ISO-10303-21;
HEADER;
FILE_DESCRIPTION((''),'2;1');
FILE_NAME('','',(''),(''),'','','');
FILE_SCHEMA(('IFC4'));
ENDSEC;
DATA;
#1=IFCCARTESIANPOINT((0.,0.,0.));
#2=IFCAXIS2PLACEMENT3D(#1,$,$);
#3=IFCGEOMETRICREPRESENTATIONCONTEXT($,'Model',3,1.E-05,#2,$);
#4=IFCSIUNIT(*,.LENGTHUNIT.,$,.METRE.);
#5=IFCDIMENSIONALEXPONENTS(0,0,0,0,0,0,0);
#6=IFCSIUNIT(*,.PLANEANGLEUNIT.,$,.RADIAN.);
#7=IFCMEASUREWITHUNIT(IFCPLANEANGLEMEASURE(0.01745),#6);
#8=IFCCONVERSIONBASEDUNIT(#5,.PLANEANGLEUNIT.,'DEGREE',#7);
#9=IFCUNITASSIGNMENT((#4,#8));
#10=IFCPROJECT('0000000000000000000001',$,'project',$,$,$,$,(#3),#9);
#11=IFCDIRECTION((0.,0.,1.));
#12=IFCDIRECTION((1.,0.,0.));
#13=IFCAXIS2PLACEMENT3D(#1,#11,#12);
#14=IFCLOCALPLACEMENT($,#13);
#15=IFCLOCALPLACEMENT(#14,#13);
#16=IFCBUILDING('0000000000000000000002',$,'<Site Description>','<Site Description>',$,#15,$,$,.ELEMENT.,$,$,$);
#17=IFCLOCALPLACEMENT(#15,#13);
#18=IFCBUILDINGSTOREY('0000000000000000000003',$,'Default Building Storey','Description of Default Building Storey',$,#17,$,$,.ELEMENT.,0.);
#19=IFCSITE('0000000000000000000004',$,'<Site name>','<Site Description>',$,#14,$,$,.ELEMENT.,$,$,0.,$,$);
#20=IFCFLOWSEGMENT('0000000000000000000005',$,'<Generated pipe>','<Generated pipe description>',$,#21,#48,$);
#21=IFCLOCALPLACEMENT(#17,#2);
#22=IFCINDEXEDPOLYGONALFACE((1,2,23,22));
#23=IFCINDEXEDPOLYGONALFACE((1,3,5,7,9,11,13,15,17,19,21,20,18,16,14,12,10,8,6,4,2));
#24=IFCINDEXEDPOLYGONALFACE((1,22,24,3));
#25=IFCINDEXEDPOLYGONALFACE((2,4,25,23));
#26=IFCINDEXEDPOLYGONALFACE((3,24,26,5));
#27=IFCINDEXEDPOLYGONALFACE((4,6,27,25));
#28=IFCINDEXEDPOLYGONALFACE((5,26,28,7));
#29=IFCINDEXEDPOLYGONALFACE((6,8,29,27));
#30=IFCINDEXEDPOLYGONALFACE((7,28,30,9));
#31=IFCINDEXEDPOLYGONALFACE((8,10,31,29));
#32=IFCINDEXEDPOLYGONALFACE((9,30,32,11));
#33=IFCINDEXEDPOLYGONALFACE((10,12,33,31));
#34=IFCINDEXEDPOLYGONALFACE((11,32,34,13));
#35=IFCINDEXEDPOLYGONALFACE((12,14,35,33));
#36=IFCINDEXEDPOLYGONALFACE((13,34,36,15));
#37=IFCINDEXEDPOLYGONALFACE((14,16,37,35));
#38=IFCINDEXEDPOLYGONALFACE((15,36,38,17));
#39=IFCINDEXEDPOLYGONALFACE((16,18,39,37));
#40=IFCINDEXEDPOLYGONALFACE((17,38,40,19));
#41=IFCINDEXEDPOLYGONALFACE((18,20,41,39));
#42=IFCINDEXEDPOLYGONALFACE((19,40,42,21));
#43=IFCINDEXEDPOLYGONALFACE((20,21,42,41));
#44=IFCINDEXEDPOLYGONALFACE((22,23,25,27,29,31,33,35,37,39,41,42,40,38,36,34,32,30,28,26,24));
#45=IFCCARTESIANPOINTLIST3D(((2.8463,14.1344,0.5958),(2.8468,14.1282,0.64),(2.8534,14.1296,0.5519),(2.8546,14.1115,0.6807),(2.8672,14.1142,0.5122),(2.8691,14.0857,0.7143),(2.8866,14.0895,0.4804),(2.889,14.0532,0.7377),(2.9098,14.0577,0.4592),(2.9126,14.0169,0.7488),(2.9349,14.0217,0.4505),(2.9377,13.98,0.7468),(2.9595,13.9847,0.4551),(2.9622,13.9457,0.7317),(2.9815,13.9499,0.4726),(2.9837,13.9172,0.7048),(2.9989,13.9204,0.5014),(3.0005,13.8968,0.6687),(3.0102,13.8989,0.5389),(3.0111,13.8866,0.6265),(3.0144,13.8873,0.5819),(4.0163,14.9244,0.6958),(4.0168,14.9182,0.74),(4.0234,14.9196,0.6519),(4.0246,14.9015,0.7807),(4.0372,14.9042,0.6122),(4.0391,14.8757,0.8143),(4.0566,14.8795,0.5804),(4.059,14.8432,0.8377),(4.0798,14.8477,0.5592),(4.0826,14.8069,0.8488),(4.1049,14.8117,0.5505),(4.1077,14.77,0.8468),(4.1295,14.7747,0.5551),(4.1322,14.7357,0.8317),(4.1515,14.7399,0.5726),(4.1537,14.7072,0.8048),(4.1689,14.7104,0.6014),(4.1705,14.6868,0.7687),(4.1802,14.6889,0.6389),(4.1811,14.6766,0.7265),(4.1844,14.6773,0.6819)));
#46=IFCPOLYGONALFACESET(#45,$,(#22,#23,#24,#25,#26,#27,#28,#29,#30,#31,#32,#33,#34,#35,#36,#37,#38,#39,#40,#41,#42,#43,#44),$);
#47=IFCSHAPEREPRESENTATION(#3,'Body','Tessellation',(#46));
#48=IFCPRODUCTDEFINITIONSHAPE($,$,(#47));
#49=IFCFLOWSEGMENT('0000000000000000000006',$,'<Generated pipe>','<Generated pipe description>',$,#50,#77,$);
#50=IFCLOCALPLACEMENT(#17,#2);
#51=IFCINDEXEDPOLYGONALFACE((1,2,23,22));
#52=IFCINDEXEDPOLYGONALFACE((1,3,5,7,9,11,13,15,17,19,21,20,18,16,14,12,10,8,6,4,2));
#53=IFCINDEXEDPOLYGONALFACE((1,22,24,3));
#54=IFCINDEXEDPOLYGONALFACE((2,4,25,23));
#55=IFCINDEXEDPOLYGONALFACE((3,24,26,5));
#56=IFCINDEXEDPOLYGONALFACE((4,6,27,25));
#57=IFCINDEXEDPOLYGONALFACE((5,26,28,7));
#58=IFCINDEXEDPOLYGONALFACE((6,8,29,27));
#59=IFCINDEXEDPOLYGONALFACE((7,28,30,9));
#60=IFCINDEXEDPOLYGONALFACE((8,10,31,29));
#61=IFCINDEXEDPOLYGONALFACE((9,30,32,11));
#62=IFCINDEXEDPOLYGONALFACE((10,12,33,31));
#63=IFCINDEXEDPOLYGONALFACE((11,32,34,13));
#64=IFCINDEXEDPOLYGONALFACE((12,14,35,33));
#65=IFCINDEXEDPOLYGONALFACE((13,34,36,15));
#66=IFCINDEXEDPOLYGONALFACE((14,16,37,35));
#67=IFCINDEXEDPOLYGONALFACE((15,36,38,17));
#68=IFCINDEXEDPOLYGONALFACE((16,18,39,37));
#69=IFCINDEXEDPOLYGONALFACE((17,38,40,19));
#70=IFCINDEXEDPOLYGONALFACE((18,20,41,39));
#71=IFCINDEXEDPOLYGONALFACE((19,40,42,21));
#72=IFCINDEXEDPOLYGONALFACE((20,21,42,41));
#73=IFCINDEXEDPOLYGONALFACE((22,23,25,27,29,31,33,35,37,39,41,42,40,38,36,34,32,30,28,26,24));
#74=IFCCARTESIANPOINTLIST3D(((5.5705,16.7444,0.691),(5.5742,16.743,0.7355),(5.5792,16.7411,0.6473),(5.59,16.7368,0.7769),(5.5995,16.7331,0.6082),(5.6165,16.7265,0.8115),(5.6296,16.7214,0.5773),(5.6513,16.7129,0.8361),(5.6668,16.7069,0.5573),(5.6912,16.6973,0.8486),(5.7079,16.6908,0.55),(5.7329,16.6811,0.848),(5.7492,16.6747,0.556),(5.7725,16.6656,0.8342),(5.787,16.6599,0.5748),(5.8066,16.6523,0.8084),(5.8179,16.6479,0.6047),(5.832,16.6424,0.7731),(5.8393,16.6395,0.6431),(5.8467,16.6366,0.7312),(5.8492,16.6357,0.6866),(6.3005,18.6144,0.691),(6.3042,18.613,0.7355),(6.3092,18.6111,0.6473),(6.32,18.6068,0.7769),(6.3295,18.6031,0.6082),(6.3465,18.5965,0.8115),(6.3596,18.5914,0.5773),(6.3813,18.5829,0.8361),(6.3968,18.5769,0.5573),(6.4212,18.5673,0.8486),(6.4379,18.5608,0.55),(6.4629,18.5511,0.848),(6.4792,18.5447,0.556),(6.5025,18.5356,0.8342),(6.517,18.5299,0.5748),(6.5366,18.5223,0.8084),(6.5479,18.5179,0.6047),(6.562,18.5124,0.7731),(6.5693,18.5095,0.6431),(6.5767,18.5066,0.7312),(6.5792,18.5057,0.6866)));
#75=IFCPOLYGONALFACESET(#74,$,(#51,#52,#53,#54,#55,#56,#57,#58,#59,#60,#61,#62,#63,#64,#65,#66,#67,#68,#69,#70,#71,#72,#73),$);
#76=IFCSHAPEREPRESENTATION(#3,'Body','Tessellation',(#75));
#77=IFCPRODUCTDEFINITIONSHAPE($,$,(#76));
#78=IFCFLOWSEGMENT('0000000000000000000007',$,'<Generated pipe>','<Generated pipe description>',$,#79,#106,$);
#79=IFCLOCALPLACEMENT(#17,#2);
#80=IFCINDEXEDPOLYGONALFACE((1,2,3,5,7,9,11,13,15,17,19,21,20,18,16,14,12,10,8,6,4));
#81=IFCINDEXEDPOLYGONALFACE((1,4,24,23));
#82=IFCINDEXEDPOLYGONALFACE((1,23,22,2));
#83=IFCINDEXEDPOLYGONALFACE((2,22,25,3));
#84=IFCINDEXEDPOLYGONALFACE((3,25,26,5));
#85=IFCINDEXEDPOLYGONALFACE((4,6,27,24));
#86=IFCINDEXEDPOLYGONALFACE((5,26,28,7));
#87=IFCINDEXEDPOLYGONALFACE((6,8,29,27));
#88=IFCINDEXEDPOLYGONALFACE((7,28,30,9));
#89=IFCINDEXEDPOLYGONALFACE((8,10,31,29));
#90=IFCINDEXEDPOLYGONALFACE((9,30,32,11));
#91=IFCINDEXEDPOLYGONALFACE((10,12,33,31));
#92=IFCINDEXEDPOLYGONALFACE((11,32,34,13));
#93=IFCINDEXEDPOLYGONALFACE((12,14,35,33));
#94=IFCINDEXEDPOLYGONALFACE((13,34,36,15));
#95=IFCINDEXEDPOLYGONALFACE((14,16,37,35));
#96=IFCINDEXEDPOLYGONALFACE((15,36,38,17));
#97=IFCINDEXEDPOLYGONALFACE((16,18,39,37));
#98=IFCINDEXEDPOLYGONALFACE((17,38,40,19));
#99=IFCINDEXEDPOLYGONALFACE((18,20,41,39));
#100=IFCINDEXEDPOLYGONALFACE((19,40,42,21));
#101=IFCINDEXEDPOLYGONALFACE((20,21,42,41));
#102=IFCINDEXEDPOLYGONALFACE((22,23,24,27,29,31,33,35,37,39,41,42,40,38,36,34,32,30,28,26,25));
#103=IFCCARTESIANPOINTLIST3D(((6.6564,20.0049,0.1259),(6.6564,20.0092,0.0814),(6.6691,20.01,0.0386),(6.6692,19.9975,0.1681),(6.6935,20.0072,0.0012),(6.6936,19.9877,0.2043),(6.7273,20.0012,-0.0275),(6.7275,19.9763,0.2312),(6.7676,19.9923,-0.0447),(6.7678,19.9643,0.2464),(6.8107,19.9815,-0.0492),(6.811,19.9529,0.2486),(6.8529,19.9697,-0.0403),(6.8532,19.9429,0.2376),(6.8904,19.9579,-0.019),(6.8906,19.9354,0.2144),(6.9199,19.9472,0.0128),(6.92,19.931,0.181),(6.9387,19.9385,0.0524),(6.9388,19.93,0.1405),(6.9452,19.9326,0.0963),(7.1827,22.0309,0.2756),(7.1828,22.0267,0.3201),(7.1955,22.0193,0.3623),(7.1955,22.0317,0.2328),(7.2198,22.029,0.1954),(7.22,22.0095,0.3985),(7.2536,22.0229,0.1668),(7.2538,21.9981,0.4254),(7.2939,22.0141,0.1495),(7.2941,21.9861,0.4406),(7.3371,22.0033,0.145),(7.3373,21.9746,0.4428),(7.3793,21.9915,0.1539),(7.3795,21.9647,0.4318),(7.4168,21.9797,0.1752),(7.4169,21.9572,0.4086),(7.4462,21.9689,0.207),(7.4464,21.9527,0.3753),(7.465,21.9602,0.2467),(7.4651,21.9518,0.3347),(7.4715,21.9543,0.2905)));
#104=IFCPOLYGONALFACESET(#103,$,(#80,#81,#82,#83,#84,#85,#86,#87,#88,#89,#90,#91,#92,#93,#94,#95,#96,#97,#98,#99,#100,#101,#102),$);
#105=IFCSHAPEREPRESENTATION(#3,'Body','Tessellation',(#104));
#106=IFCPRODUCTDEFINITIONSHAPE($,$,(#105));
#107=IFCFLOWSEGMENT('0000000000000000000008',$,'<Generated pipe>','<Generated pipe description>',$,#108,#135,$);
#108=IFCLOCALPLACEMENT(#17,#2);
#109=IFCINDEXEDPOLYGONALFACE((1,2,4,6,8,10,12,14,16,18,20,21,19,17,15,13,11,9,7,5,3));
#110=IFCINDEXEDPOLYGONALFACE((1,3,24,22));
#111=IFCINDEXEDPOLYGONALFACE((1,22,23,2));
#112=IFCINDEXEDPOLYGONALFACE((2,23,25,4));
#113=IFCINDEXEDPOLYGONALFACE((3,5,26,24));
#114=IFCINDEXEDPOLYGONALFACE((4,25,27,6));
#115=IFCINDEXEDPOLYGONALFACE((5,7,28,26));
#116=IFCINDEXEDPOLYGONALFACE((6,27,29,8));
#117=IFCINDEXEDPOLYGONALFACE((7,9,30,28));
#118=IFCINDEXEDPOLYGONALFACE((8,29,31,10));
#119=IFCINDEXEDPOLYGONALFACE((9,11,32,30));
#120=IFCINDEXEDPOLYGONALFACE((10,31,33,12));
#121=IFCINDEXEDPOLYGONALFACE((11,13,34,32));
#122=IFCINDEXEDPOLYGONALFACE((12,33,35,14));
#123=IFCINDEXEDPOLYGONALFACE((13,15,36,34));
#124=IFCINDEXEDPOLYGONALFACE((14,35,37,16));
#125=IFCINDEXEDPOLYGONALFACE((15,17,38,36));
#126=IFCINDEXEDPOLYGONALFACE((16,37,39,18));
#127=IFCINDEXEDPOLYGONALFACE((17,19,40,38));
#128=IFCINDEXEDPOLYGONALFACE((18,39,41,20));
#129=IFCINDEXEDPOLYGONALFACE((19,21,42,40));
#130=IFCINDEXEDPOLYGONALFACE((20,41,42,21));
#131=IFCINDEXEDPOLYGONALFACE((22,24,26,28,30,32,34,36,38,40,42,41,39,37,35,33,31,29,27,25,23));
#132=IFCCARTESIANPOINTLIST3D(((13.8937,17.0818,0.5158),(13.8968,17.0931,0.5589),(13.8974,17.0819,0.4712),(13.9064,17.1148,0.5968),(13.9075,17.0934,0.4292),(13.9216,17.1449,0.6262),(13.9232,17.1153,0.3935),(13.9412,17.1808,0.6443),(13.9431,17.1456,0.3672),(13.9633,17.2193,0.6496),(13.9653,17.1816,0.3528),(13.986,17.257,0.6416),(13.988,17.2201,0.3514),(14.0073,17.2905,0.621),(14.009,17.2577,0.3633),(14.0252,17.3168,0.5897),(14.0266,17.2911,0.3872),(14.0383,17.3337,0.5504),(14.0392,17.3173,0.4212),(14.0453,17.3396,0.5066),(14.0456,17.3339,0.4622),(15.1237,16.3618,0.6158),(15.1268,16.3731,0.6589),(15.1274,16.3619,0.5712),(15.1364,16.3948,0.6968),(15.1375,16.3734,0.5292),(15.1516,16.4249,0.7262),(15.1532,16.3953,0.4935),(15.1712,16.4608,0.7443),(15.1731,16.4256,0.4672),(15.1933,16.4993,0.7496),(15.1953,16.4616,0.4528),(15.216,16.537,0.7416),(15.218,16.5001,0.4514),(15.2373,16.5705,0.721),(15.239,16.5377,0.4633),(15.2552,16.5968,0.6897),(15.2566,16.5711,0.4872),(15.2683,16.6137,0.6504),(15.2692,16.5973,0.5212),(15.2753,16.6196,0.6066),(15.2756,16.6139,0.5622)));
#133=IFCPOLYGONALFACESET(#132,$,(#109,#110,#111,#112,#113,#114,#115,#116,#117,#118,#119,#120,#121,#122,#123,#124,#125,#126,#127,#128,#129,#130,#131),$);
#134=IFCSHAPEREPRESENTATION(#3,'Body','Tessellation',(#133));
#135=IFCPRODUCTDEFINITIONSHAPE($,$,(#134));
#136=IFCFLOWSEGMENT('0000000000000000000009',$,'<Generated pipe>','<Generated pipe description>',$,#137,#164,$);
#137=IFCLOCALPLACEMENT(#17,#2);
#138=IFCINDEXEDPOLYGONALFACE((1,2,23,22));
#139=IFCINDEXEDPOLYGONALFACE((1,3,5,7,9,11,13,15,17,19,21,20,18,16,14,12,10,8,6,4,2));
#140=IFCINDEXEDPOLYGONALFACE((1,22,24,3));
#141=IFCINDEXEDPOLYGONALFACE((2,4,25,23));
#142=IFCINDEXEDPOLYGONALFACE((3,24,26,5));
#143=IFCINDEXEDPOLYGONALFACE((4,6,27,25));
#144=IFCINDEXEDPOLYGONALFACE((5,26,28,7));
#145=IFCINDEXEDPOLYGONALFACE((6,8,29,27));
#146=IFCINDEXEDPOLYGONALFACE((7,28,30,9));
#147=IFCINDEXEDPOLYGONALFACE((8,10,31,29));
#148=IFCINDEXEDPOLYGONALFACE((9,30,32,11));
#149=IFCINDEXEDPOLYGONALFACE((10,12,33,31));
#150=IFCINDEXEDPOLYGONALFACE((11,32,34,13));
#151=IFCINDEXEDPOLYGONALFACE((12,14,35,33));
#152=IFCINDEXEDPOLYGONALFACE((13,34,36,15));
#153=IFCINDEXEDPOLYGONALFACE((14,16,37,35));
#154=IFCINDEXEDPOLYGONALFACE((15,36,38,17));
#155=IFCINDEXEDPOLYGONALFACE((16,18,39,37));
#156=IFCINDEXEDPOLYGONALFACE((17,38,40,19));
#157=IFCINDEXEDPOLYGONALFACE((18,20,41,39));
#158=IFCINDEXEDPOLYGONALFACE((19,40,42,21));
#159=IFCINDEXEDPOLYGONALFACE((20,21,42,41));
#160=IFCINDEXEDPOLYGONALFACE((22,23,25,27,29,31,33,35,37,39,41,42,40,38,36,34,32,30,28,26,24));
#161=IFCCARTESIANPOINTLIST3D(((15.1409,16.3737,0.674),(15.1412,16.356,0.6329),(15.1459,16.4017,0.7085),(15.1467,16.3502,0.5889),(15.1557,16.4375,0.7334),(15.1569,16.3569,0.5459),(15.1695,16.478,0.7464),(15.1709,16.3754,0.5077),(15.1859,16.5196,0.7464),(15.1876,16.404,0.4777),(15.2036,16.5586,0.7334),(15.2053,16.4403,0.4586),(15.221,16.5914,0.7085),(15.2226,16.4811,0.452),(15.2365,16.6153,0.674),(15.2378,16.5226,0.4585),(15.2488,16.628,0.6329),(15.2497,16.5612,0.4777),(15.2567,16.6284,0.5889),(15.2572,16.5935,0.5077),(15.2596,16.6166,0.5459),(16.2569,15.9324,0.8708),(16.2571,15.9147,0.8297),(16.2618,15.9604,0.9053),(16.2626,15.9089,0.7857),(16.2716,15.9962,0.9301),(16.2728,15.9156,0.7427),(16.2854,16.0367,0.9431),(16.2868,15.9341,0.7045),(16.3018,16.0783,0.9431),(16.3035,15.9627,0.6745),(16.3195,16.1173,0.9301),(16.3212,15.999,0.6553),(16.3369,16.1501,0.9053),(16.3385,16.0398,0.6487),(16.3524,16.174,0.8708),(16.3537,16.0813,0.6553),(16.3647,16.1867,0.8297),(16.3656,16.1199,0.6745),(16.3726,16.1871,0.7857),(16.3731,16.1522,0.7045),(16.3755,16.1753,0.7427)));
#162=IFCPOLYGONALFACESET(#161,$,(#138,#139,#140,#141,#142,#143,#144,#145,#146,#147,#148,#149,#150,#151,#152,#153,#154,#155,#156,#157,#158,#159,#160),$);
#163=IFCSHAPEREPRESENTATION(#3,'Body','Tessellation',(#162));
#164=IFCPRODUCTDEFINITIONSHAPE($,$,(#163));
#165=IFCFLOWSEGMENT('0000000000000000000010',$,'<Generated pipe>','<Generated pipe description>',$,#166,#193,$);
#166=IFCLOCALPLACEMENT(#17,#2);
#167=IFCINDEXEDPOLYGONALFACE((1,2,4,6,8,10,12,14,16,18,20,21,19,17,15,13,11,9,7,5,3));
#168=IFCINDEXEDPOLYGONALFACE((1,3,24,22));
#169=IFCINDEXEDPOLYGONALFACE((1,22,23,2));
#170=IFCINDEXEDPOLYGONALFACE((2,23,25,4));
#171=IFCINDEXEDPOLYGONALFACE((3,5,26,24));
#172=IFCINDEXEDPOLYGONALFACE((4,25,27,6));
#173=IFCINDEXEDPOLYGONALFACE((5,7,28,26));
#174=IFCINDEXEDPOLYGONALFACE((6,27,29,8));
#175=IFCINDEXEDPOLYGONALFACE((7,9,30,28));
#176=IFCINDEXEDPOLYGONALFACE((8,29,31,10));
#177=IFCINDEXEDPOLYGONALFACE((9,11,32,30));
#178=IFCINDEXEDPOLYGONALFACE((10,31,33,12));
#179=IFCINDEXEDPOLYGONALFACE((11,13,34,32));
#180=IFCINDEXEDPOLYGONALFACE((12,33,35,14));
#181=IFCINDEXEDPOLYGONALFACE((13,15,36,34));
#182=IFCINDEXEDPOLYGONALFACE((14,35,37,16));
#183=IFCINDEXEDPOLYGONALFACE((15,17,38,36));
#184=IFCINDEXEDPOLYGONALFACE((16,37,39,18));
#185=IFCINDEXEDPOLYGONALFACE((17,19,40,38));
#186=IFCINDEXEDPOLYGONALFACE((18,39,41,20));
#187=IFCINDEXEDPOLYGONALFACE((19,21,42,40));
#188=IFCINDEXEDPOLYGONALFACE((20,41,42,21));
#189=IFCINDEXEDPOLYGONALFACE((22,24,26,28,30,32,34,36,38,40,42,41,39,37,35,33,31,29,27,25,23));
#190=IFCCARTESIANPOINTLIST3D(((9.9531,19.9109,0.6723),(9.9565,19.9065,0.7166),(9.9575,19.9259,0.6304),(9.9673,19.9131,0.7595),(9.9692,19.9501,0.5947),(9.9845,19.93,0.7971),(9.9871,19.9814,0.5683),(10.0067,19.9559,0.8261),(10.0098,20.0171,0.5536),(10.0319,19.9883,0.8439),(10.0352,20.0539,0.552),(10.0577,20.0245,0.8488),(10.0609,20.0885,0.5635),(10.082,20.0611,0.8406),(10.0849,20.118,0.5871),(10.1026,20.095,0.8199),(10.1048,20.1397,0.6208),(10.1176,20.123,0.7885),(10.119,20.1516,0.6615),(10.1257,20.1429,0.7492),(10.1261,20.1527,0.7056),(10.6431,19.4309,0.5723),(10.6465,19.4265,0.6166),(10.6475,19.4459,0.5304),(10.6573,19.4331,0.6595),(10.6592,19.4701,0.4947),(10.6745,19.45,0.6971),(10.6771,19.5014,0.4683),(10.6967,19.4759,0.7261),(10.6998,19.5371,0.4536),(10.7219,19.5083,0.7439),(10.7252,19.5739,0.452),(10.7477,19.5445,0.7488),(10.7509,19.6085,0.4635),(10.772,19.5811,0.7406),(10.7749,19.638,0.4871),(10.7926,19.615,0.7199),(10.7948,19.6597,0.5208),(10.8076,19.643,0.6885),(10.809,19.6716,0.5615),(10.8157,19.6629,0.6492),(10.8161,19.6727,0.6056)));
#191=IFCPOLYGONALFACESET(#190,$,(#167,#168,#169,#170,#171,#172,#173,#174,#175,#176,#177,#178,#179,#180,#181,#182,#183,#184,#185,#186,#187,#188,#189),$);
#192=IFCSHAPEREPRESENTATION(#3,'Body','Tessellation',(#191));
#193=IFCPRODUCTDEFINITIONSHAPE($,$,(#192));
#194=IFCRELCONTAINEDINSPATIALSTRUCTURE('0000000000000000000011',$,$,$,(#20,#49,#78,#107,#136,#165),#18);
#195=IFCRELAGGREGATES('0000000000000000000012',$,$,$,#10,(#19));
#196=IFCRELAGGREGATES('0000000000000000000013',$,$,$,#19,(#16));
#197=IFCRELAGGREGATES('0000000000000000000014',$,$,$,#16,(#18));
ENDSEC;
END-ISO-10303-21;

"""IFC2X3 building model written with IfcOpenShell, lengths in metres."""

from ifc_helpers import new_model, entity, si_unit, converted_unit, frame, origin, origin_with_axes, origin_2d_with_axis, place, context, project, spatial, circle, extrude, element, save


model = new_model("IFC2X3")

# Units and contexts
model_context = context("Model", 3, precision=1e-05, world=origin())
ifc_project = project(units=[si_unit("LENGTHUNIT", "METRE"), converted_unit("PLANEANGLEUNIT", "DEGREE", entity("IfcPlaneAngleMeasure", 0.01745), si_unit("PLANEANGLEUNIT", "RADIAN"), dimensions=[0, 0, 0, 0, 0, 0, 0])], contexts=[model_context])

# Site, building, storey
site_placement = place(None, origin_with_axes())
site = spatial("IfcSite", under=ifc_project, at=site_placement, Name="<Site name>", Description="<Site Description>", CompositionType="ELEMENT", RefElevation=0.0)
building_placement = place(site_placement, origin_with_axes())
building = spatial("IfcBuilding", under=site, at=building_placement, Name="<Site Description>", Description="<Site Description>", CompositionType="ELEMENT")
storey_placement = place(building_placement, origin_with_axes())
storey = spatial("IfcBuildingStorey", under=building, at=storey_placement, Name="Default Building Storey", Description="Description of Default Building Storey", CompositionType="ELEMENT", Elevation=0.0)

# Flow segments
flow_segment_1_placement = place(storey_placement, frame((2.93, 14.01, 0.6), z_axis=(0.826695, 0.558196, 0.070658), x_axis=(-0.405909, 0.504713, 0.761907)))
element("IfcFlowSegment", 1, at=flow_segment_1_placement, inside=storey, Name="<Generated pipe>", Description="<Generated pipe description>", context=model_context, shape_type="SweptSolid", body=[
    extrude(circle(Radius=0.15, at=origin_2d_with_axis()), origin_with_axes(), (0.0, 0.0, 1.0), 1.4153),
])
flow_segment_2_placement = place(storey_placement, frame((5.71, 16.69, 0.7), z_axis=(0.363648, 0.931536, 0.0), x_axis=(0.911161, -0.355694, 0.20801)))
element("IfcFlowSegment", 2, at=flow_segment_2_placement, inside=storey, Name="<Generated pipe>", Description="<Generated pipe description>", context=model_context, shape_type="SweptSolid", body=[
    extrude(circle(Radius=0.15, at=origin_2d_with_axis()), origin_with_axes(), (0.0, 0.0, 1.0), 2.0074),
])
flow_segment_3_placement = place(storey_placement, frame((6.8, 19.97, 0.1), z_axis=(0.250849, 0.963591, 0.092562), x_axis=(0.925235, -0.266777, 0.269758)))
element("IfcFlowSegment", 3, at=flow_segment_3_placement, inside=storey, Name="<Generated pipe>", Description="<Generated pipe description>", context=model_context, shape_type="SweptSolid", body=[
    extrude(circle(Radius=0.15, at=origin_2d_with_axis()), origin_with_axes(), (0.0, 0.0, 1.0), 2.0982),
])
flow_segment_4_placement = place(storey_placement, frame((13.97, 17.21, 0.5), z_axis=(0.860898, -0.50394, 0.069992), x_axis=(0.50203, 0.863734, 0.043922)))
element("IfcFlowSegment", 4, at=flow_segment_4_placement, inside=storey, Name="<Generated pipe>", Description="<Generated pipe description>", context=model_context, shape_type="SweptSolid", body=[
    extrude(circle(Radius=0.15, at=origin_2d_with_axis()), origin_with_axes(), (0.0, 0.0, 1.0), 1.4287),
])
flow_segment_5_placement = place(storey_placement, frame((15.2, 16.49, 0.6), z_axis=(0.91767, -0.362907, 0.161806), x_axis=(0.024027, 0.457154, 0.889063)))
element("IfcFlowSegment", 5, at=flow_segment_5_placement, inside=storey, Name="<Generated pipe>", Description="<Generated pipe description>", context=model_context, shape_type="SweptSolid", body=[
    extrude(circle(Radius=0.15, at=origin_2d_with_axis()), origin_with_axes(), (0.0, 0.0, 1.0), 1.216),
])
flow_segment_6_placement = place(storey_placement, frame((10.04, 20.03, 0.7), z_axis=(0.815156, -0.567065, -0.118139), x_axis=(0.571026, 0.752477, 0.328187)))
element("IfcFlowSegment", 6, at=flow_segment_6_placement, inside=storey, Name="<Generated pipe>", Description="<Generated pipe description>", context=model_context, shape_type="SweptSolid", body=[
    extrude(circle(Radius=0.15, at=origin_2d_with_axis()), origin_with_axes(), (0.0, 0.0, 1.0), 0.8465),
])

save(model, "model.ifc")
